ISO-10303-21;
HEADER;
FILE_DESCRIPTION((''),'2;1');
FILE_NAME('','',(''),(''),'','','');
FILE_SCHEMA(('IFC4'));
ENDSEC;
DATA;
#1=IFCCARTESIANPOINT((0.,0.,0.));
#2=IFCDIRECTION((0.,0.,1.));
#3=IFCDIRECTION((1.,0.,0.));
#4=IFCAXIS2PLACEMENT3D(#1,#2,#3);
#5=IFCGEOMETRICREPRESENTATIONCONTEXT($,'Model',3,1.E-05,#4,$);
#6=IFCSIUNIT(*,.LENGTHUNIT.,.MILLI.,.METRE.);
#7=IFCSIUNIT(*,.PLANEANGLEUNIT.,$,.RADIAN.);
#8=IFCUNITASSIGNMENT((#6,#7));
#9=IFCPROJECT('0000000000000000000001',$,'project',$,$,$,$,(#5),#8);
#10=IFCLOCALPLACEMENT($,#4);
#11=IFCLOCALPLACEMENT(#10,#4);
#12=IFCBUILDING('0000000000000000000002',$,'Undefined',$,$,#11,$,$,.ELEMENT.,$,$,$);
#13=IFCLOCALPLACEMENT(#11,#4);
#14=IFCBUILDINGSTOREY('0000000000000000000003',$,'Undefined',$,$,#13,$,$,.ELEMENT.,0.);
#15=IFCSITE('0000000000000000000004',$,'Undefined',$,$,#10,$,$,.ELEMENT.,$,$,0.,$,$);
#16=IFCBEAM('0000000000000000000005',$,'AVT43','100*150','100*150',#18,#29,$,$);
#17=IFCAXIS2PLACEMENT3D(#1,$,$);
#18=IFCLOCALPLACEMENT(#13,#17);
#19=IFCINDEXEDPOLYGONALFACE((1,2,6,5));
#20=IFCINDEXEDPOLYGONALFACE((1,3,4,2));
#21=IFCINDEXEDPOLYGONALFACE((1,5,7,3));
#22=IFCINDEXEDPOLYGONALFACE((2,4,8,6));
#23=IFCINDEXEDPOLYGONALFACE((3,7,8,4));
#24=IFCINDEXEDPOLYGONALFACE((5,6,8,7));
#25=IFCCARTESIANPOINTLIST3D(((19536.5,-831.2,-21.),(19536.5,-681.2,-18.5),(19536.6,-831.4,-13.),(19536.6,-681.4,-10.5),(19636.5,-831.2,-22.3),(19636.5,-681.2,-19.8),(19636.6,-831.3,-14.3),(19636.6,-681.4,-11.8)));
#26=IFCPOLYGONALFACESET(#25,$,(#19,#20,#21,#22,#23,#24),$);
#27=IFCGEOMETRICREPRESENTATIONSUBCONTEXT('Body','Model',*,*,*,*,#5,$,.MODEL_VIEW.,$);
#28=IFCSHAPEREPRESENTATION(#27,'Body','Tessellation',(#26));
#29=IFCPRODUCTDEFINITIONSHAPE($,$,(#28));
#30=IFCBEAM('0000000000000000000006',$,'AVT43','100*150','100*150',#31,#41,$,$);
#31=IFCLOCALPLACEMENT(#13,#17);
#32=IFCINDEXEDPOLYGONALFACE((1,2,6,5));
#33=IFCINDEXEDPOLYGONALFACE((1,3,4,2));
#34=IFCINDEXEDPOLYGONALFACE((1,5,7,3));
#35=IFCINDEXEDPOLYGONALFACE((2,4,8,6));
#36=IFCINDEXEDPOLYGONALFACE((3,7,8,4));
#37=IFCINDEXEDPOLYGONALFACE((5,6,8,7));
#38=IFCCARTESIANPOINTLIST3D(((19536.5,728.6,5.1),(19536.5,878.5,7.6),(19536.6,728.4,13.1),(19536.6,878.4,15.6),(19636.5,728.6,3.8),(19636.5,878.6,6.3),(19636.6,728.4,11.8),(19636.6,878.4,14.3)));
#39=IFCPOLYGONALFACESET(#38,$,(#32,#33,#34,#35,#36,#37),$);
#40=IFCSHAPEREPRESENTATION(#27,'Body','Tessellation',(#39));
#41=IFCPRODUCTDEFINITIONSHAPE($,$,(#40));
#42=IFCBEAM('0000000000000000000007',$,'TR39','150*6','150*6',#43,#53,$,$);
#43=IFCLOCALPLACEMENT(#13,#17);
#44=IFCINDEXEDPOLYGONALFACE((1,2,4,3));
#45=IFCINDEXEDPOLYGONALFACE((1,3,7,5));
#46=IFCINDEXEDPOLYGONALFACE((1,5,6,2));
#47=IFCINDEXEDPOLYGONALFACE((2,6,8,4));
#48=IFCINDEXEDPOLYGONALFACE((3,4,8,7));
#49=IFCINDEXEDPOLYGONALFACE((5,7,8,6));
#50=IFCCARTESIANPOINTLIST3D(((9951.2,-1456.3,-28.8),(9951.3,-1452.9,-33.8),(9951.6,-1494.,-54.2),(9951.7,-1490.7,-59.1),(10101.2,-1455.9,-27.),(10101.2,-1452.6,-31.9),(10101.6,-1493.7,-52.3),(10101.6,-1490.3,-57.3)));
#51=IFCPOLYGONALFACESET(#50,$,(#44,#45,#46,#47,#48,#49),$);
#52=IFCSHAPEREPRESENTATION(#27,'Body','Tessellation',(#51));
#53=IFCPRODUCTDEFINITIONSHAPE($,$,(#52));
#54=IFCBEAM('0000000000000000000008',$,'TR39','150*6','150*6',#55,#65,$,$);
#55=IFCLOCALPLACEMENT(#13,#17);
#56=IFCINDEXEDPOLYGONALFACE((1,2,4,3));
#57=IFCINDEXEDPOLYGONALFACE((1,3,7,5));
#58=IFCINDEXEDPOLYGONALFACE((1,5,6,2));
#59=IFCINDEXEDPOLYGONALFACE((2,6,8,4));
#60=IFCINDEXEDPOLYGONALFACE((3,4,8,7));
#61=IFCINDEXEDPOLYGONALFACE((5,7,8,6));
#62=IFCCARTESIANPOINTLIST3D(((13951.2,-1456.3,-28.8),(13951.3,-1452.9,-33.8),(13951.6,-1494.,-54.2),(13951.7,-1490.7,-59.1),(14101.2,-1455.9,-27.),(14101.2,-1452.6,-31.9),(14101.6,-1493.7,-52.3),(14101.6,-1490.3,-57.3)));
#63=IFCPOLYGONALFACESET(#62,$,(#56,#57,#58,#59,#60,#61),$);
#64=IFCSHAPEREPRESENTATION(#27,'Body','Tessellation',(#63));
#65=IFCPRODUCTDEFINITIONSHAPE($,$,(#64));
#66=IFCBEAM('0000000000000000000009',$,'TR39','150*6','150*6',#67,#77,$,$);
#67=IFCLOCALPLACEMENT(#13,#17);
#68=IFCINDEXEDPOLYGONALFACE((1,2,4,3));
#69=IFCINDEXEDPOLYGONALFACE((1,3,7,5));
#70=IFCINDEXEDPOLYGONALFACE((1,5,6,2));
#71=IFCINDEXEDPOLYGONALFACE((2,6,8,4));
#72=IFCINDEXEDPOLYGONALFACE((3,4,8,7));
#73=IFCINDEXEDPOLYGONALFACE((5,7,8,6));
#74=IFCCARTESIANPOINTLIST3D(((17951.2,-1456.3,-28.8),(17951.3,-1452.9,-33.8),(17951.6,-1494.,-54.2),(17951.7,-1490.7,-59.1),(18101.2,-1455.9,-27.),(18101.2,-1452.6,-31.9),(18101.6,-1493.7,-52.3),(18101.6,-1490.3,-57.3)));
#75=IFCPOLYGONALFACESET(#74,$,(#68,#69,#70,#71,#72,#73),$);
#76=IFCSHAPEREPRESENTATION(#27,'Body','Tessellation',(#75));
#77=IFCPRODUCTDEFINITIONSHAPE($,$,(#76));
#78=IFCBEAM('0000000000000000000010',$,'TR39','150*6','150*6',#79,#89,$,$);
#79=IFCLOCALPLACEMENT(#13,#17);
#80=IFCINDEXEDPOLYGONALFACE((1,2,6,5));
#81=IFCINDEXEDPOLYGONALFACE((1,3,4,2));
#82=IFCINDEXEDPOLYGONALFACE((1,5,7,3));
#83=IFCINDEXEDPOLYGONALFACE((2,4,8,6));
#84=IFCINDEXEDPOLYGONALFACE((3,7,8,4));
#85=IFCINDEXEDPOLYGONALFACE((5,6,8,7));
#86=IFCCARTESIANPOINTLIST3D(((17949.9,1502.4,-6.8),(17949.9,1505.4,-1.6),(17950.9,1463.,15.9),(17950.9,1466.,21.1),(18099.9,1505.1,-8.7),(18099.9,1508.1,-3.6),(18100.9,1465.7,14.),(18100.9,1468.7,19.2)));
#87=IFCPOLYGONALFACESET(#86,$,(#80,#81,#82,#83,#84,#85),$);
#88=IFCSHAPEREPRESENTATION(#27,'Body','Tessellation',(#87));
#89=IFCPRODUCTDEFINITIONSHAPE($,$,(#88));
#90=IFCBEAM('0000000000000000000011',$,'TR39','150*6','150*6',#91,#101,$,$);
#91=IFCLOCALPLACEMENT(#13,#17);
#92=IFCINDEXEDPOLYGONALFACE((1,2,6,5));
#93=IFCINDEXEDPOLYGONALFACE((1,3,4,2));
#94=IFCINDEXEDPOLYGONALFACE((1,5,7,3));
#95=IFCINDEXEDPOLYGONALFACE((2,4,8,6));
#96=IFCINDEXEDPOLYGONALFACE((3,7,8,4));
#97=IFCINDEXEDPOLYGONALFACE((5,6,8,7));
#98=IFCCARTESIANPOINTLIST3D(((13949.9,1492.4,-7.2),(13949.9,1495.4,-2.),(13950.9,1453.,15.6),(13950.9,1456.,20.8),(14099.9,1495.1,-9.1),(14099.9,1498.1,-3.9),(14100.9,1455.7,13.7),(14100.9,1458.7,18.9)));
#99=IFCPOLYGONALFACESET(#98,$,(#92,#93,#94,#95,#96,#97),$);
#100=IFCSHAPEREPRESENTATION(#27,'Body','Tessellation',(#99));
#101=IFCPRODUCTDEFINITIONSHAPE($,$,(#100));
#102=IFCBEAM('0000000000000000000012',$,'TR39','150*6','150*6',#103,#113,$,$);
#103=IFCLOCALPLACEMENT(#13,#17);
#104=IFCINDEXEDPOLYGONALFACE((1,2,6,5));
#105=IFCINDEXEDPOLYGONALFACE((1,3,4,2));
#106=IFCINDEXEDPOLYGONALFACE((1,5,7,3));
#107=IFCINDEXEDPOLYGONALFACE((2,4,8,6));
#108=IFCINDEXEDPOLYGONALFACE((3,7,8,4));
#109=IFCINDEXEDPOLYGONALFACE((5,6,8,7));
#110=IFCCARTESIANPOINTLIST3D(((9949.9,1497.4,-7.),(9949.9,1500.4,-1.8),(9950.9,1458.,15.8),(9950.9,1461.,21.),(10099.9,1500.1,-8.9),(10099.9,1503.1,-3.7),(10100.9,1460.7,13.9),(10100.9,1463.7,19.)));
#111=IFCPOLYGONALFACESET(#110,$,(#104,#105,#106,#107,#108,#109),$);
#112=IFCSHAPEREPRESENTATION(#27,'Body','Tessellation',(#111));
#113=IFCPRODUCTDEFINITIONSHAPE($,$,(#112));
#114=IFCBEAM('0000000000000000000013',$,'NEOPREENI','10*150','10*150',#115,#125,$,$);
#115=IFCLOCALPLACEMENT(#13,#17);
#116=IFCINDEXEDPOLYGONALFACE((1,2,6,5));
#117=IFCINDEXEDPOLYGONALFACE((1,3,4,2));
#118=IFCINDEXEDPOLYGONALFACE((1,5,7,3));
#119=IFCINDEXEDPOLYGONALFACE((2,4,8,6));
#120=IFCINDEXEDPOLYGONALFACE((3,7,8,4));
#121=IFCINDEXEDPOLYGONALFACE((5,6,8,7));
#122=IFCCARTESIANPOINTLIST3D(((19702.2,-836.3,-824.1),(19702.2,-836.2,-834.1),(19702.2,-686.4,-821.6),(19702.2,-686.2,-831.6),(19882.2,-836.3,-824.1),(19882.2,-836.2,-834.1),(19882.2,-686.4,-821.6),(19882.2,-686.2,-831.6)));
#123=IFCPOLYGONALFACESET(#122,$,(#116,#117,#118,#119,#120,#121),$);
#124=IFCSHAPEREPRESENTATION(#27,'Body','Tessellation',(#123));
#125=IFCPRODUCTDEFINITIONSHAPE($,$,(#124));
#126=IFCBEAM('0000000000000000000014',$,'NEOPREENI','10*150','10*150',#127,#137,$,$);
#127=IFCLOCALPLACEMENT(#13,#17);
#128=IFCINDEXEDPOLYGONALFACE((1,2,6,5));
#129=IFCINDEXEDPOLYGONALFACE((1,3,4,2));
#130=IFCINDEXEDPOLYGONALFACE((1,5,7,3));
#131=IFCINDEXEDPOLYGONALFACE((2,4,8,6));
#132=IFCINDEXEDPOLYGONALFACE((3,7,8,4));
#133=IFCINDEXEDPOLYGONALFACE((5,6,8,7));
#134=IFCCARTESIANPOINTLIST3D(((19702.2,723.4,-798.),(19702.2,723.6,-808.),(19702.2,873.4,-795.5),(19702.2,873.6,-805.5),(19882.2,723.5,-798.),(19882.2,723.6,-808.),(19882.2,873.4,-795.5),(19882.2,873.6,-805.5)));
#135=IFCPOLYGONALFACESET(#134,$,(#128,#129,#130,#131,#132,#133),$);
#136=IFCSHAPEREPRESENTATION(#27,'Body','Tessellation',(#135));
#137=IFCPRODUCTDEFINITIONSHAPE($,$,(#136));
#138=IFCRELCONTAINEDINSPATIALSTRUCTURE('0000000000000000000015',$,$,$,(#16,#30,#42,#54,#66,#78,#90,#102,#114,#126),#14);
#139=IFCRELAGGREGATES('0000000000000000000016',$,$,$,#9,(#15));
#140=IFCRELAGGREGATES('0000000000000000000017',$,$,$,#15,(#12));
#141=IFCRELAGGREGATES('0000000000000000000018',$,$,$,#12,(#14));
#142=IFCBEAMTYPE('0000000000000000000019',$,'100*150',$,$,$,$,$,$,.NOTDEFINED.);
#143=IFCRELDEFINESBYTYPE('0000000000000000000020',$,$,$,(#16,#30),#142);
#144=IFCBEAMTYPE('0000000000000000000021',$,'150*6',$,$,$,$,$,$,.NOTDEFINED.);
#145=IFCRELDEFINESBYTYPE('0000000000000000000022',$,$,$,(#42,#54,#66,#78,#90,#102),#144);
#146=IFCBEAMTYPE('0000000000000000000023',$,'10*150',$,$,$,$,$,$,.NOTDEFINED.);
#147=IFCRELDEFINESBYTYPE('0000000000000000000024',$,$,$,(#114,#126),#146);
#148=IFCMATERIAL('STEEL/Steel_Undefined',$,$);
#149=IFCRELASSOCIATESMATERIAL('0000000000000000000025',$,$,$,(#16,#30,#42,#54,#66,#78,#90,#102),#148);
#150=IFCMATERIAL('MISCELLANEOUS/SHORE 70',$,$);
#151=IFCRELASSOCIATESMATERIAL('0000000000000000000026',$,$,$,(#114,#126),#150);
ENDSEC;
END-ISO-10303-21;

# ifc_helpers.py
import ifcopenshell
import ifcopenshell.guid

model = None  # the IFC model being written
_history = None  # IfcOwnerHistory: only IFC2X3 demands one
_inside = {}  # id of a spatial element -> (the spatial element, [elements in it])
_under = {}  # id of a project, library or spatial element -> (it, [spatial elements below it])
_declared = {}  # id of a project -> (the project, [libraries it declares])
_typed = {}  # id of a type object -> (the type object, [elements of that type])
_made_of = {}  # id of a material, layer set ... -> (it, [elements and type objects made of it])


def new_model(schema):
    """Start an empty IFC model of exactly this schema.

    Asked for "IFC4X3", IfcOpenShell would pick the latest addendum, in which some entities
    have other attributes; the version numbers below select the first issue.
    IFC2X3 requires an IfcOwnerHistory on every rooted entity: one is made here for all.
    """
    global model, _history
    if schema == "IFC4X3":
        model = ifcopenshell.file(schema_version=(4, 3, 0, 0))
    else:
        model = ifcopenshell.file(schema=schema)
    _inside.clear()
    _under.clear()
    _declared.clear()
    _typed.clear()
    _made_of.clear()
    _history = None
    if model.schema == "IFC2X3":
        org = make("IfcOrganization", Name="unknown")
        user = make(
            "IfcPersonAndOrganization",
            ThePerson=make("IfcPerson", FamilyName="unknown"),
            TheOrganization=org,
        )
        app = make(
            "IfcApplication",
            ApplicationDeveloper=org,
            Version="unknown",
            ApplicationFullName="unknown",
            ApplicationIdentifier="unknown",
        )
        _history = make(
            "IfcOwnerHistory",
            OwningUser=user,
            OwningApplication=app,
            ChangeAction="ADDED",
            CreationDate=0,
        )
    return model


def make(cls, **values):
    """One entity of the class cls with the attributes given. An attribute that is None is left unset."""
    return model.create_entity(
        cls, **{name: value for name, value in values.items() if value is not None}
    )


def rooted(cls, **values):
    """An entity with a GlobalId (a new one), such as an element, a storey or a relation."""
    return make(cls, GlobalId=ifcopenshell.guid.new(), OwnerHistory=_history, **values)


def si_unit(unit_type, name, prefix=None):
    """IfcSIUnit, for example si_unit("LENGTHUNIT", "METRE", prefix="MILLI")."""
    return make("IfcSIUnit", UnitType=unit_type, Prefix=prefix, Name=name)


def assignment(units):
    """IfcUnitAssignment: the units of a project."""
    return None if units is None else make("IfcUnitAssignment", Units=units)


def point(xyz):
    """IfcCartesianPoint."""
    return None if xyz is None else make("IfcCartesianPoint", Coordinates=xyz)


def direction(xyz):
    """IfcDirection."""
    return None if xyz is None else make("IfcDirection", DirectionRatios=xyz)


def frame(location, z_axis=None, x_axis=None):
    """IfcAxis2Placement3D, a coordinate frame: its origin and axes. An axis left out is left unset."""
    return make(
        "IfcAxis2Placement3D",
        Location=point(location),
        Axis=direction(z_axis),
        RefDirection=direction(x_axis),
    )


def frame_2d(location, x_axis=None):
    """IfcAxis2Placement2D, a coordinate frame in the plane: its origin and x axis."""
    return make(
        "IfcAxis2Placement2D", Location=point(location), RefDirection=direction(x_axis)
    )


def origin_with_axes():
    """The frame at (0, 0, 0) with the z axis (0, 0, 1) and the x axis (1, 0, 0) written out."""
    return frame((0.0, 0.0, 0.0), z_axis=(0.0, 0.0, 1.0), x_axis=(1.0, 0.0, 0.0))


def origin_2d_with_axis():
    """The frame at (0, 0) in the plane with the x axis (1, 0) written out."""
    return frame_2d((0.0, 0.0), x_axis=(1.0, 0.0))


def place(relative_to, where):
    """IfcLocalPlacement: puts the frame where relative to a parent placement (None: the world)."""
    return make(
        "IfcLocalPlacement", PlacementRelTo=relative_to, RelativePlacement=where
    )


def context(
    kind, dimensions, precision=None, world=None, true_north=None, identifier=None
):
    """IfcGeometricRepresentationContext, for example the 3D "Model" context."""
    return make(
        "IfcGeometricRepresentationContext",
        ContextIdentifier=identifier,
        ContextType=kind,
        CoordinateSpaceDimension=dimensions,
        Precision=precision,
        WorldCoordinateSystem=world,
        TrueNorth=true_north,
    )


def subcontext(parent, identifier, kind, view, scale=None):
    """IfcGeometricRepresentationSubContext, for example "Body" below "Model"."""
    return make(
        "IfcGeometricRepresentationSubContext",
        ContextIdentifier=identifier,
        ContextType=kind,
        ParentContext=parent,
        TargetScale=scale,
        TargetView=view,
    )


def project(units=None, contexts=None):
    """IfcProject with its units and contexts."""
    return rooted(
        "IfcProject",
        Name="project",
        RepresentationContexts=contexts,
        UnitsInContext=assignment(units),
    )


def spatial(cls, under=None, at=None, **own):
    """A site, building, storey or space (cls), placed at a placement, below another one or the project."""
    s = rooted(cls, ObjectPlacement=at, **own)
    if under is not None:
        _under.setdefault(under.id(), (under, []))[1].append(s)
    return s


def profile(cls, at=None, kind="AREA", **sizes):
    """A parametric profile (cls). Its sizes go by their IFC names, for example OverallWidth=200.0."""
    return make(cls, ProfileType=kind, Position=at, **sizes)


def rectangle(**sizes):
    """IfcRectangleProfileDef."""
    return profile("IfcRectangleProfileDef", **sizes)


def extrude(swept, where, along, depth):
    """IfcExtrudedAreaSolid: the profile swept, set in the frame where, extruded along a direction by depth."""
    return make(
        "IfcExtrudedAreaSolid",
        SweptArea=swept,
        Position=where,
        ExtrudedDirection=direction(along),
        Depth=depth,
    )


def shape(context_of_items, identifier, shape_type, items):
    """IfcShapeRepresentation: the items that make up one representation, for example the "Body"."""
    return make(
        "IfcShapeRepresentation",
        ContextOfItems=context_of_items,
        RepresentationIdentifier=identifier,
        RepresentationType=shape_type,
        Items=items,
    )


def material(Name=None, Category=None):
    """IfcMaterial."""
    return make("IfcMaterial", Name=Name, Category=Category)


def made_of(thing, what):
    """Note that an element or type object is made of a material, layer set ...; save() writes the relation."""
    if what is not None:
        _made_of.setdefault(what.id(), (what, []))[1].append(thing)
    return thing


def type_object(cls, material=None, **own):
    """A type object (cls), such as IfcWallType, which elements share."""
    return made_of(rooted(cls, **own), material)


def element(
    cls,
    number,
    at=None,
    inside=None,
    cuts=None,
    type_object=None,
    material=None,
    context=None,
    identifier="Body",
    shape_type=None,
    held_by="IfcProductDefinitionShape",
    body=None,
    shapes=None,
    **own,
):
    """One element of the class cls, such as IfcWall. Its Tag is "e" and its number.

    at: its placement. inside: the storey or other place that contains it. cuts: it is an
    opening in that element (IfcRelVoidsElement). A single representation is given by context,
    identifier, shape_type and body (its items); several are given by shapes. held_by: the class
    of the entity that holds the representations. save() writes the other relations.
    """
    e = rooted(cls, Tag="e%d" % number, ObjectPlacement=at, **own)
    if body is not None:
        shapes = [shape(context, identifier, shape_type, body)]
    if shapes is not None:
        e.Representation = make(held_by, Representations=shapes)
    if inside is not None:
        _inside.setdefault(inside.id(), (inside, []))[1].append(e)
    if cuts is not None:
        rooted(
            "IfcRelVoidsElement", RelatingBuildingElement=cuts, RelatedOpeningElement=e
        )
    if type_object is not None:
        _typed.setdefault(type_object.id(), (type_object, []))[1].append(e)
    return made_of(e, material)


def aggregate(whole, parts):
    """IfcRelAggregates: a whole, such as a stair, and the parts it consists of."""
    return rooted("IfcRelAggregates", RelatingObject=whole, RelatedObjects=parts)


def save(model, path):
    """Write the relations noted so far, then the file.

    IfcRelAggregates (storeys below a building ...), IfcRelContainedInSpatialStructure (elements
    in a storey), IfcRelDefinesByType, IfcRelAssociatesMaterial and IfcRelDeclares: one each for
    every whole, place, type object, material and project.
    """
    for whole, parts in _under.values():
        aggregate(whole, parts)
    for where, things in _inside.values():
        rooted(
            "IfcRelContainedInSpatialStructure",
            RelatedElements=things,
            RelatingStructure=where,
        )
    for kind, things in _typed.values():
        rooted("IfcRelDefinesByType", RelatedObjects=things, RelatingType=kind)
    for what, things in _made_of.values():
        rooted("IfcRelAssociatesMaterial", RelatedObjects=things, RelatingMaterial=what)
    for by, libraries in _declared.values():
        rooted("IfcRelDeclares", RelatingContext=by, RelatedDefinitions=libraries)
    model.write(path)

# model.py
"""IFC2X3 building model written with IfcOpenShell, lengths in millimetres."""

from ifc_helpers import new_model, si_unit, frame, origin_with_axes, origin_2d_with_axis, place, context, subcontext, project, spatial, rectangle, extrude, material, type_object, element, save


model = new_model("IFC2X3")

# Units and contexts
model_context = context("Model", 3, precision=1e-05, world=origin_with_axes())
body_context = subcontext(model_context, "Body", "Model", "MODEL_VIEW")
ifc_project = project(units=[si_unit("LENGTHUNIT", "METRE", prefix="MILLI"), si_unit("PLANEANGLEUNIT", "RADIAN")], contexts=[model_context])

# Site, building, storey
site_placement = place(None, origin_with_axes())
site = spatial("IfcSite", under=ifc_project, at=site_placement, Name="Undefined", CompositionType="ELEMENT", RefElevation=0.0)
building_placement = place(site_placement, origin_with_axes())
building = spatial("IfcBuilding", under=site, at=building_placement, Name="Undefined", CompositionType="ELEMENT")
storey_placement = place(building_placement, origin_with_axes())
storey = spatial("IfcBuildingStorey", under=building, at=storey_placement, Name="Undefined", CompositionType="ELEMENT", Elevation=0.0)

# Beams
ifc_material_1 = material(Name="STEEL/Steel_Undefined")
beam_type_1 = type_object("IfcBeamType", Name="100*150", PredefinedType="NOTDEFINED")
beam_1_placement = place(storey_placement, frame((19586.5, -756.2, -20.4), z_axis=(-0.999921, -0.000211, 0.0126), x_axis=(0.012601, -0.016713, 0.999781)))
element("IfcBeam", 1, at=beam_1_placement, inside=storey, type_object=beam_type_1, material=ifc_material_1, Name="AVT43", Description="100*150", ObjectType="100*150", context=body_context, shape_type="SweptSolid", body=[
    extrude(rectangle(XDim=150.0, YDim=100.0, at=origin_2d_with_axis()), frame((8.0, 0.0, 0.0), z_axis=(-1.0, 0.0, 0.0), x_axis=(0.0, -1.0, 0.0)), (0.0, 0.0, 1.0), 8.0),
])
beam_2_placement = place(storey_placement, frame((19586.5, 803.6, 5.7), z_axis=(-0.999921, -0.000211, 0.0126), x_axis=(0.012601, -0.016713, 0.999781)))
element("IfcBeam", 2, at=beam_2_placement, inside=storey, type_object=beam_type_1, material=ifc_material_1, Name="AVT43", Description="100*150", ObjectType="100*150", context=body_context, shape_type="SweptSolid", body=[
    extrude(rectangle(XDim=150.0, YDim=100.0, at=origin_2d_with_axis()), frame((8.0, 0.0, 0.0), z_axis=(-1.0, 0.0, 0.0), x_axis=(0.0, -1.0, 0.0)), (0.0, 0.0, 1.0), 8.0),
])
beam_type_2 = type_object("IfcBeamType", Name="150*6", PredefinedType="NOTDEFINED")
for number, where, z_axis, x_axis, name in (
    (3, (10026.6, -1492.2, -55.7), (-0.999922, -0.002351, -0.012227), (-0.008769, 0.83011, 0.557531), "TR39"),
    (4, (14026.6, -1492.2, -55.7), (-0.999922, -0.002351, -0.012227), (-0.008769, 0.83011, 0.557531), "TR39"),
):
    element("IfcBeam", number, at=place(storey_placement, frame(where, z_axis=z_axis, x_axis=x_axis)), inside=storey, type_object=beam_type_2, material=ifc_material_1, Name=name, Description="150*6", ObjectType="150*6", context=body_context, shape_type="SweptSolid", body=[
        extrude(rectangle(XDim=6.0, YDim=150.0, at=origin_2d_with_axis()), frame((45.5, 0.0, 0.0), z_axis=(-1.0, 0.0, 0.0), x_axis=(0.0, -1.0, 0.0)), (0.0, 0.0, 1.0), 45.5),
    ])
beam_3_placement = place(storey_placement, frame((18026.6, -1492.2, -55.7), z_axis=(-0.999922, -0.002351, -0.012227), x_axis=(-0.008769, 0.83011, 0.557531)))
element("IfcBeam", 5, at=beam_3_placement, inside=storey, type_object=beam_type_2, material=ifc_material_1, Name="TR39", Description="150*6", ObjectType="150*6", context=body_context, shape_type="SweptSolid", body=[
    extrude(rectangle(XDim=6.0, YDim=150.0, at=origin_2d_with_axis()), frame((45.5, 0.0, 0.0), z_axis=(-1.0, 0.0, 0.0), x_axis=(0.0, -1.0, 0.0)), (0.0, 0.0, 1.0), 45.5),
])
beam_4_placement = place(storey_placement, frame((18024.9, 1505.2, -5.2), z_axis=(0.999754, 0.018164, -0.012752), x_axis=(0.022108, -0.865485, 0.500446)))
element("IfcBeam", 6, at=beam_4_placement, inside=storey, type_object=beam_type_2, material=ifc_material_1, Name="TR39", Description="150*6", ObjectType="150*6", context=body_context, shape_type="SweptSolid", body=[
    extrude(rectangle(XDim=6.0, YDim=150.0, at=origin_2d_with_axis()), frame((45.5, 0.0, 0.0), z_axis=(-1.0, 0.0, 0.0), x_axis=(0.0, -1.0, 0.0)), (0.0, 0.0, 1.0), 45.5),
])
for number, where, z_axis, x_axis, name in (
    (7, (14024.9, 1495.2, -5.5), (0.999754, 0.018164, -0.012752), (0.022108, -0.865485, 0.500446), "TR39"),
    (8, (10024.9, 1500.2, -5.4), (0.999754, 0.018164, -0.012752), (0.022108, -0.865485, 0.500446), "TR39"),
):
    element("IfcBeam", number, at=place(storey_placement, frame(where, z_axis=z_axis, x_axis=x_axis)), inside=storey, type_object=beam_type_2, material=ifc_material_1, Name=name, Description="150*6", ObjectType="150*6", context=body_context, shape_type="SweptSolid", body=[
        extrude(rectangle(XDim=6.0, YDim=150.0, at=origin_2d_with_axis()), frame((45.5, 0.0, 0.0), z_axis=(-1.0, 0.0, 0.0), x_axis=(0.0, -1.0, 0.0)), (0.0, 0.0, 1.0), 45.5),
    ])
ifc_material_2 = material(Name="MISCELLANEOUS/SHORE 70")
beam_type_3 = type_object("IfcBeamType", Name="10*150", PredefinedType="NOTDEFINED")
beam_5_placement = place(storey_placement, frame((19702.2, -761.3, -827.8), z_axis=(-0.000005, -0.016723, 0.99986), x_axis=(1.0, 0.000015, 0.000005)))
element("IfcBeam", 9, at=beam_5_placement, inside=storey, type_object=beam_type_3, material=ifc_material_2, Name="NEOPREENI", Description="10*150", ObjectType="10*150", context=body_context, shape_type="SweptSolid", body=[
    extrude(rectangle(XDim=150.0, YDim=10.0, at=origin_2d_with_axis()), frame((180.0, 0.0, 0.0), z_axis=(-1.0, 0.0, 0.0), x_axis=(0.0, -1.0, 0.0)), (0.0, 0.0, 1.0), 180.0),
])
beam_6_placement = place(storey_placement, frame((19702.2, 798.5, -801.8), z_axis=(-0.000005, -0.016723, 0.99986), x_axis=(1.0, 0.000015, 0.000005)))
element("IfcBeam", 10, at=beam_6_placement, inside=storey, type_object=beam_type_3, material=ifc_material_2, Name="NEOPREENI", Description="10*150", ObjectType="10*150", context=body_context, shape_type="SweptSolid", body=[
    extrude(rectangle(XDim=150.0, YDim=10.0, at=origin_2d_with_axis()), frame((180.0, 0.0, 0.0), z_axis=(-1.0, 0.0, 0.0), x_axis=(0.0, -1.0, 0.0)), (0.0, 0.0, 1.0), 180.0),
])

save(model, "model.ifc")
